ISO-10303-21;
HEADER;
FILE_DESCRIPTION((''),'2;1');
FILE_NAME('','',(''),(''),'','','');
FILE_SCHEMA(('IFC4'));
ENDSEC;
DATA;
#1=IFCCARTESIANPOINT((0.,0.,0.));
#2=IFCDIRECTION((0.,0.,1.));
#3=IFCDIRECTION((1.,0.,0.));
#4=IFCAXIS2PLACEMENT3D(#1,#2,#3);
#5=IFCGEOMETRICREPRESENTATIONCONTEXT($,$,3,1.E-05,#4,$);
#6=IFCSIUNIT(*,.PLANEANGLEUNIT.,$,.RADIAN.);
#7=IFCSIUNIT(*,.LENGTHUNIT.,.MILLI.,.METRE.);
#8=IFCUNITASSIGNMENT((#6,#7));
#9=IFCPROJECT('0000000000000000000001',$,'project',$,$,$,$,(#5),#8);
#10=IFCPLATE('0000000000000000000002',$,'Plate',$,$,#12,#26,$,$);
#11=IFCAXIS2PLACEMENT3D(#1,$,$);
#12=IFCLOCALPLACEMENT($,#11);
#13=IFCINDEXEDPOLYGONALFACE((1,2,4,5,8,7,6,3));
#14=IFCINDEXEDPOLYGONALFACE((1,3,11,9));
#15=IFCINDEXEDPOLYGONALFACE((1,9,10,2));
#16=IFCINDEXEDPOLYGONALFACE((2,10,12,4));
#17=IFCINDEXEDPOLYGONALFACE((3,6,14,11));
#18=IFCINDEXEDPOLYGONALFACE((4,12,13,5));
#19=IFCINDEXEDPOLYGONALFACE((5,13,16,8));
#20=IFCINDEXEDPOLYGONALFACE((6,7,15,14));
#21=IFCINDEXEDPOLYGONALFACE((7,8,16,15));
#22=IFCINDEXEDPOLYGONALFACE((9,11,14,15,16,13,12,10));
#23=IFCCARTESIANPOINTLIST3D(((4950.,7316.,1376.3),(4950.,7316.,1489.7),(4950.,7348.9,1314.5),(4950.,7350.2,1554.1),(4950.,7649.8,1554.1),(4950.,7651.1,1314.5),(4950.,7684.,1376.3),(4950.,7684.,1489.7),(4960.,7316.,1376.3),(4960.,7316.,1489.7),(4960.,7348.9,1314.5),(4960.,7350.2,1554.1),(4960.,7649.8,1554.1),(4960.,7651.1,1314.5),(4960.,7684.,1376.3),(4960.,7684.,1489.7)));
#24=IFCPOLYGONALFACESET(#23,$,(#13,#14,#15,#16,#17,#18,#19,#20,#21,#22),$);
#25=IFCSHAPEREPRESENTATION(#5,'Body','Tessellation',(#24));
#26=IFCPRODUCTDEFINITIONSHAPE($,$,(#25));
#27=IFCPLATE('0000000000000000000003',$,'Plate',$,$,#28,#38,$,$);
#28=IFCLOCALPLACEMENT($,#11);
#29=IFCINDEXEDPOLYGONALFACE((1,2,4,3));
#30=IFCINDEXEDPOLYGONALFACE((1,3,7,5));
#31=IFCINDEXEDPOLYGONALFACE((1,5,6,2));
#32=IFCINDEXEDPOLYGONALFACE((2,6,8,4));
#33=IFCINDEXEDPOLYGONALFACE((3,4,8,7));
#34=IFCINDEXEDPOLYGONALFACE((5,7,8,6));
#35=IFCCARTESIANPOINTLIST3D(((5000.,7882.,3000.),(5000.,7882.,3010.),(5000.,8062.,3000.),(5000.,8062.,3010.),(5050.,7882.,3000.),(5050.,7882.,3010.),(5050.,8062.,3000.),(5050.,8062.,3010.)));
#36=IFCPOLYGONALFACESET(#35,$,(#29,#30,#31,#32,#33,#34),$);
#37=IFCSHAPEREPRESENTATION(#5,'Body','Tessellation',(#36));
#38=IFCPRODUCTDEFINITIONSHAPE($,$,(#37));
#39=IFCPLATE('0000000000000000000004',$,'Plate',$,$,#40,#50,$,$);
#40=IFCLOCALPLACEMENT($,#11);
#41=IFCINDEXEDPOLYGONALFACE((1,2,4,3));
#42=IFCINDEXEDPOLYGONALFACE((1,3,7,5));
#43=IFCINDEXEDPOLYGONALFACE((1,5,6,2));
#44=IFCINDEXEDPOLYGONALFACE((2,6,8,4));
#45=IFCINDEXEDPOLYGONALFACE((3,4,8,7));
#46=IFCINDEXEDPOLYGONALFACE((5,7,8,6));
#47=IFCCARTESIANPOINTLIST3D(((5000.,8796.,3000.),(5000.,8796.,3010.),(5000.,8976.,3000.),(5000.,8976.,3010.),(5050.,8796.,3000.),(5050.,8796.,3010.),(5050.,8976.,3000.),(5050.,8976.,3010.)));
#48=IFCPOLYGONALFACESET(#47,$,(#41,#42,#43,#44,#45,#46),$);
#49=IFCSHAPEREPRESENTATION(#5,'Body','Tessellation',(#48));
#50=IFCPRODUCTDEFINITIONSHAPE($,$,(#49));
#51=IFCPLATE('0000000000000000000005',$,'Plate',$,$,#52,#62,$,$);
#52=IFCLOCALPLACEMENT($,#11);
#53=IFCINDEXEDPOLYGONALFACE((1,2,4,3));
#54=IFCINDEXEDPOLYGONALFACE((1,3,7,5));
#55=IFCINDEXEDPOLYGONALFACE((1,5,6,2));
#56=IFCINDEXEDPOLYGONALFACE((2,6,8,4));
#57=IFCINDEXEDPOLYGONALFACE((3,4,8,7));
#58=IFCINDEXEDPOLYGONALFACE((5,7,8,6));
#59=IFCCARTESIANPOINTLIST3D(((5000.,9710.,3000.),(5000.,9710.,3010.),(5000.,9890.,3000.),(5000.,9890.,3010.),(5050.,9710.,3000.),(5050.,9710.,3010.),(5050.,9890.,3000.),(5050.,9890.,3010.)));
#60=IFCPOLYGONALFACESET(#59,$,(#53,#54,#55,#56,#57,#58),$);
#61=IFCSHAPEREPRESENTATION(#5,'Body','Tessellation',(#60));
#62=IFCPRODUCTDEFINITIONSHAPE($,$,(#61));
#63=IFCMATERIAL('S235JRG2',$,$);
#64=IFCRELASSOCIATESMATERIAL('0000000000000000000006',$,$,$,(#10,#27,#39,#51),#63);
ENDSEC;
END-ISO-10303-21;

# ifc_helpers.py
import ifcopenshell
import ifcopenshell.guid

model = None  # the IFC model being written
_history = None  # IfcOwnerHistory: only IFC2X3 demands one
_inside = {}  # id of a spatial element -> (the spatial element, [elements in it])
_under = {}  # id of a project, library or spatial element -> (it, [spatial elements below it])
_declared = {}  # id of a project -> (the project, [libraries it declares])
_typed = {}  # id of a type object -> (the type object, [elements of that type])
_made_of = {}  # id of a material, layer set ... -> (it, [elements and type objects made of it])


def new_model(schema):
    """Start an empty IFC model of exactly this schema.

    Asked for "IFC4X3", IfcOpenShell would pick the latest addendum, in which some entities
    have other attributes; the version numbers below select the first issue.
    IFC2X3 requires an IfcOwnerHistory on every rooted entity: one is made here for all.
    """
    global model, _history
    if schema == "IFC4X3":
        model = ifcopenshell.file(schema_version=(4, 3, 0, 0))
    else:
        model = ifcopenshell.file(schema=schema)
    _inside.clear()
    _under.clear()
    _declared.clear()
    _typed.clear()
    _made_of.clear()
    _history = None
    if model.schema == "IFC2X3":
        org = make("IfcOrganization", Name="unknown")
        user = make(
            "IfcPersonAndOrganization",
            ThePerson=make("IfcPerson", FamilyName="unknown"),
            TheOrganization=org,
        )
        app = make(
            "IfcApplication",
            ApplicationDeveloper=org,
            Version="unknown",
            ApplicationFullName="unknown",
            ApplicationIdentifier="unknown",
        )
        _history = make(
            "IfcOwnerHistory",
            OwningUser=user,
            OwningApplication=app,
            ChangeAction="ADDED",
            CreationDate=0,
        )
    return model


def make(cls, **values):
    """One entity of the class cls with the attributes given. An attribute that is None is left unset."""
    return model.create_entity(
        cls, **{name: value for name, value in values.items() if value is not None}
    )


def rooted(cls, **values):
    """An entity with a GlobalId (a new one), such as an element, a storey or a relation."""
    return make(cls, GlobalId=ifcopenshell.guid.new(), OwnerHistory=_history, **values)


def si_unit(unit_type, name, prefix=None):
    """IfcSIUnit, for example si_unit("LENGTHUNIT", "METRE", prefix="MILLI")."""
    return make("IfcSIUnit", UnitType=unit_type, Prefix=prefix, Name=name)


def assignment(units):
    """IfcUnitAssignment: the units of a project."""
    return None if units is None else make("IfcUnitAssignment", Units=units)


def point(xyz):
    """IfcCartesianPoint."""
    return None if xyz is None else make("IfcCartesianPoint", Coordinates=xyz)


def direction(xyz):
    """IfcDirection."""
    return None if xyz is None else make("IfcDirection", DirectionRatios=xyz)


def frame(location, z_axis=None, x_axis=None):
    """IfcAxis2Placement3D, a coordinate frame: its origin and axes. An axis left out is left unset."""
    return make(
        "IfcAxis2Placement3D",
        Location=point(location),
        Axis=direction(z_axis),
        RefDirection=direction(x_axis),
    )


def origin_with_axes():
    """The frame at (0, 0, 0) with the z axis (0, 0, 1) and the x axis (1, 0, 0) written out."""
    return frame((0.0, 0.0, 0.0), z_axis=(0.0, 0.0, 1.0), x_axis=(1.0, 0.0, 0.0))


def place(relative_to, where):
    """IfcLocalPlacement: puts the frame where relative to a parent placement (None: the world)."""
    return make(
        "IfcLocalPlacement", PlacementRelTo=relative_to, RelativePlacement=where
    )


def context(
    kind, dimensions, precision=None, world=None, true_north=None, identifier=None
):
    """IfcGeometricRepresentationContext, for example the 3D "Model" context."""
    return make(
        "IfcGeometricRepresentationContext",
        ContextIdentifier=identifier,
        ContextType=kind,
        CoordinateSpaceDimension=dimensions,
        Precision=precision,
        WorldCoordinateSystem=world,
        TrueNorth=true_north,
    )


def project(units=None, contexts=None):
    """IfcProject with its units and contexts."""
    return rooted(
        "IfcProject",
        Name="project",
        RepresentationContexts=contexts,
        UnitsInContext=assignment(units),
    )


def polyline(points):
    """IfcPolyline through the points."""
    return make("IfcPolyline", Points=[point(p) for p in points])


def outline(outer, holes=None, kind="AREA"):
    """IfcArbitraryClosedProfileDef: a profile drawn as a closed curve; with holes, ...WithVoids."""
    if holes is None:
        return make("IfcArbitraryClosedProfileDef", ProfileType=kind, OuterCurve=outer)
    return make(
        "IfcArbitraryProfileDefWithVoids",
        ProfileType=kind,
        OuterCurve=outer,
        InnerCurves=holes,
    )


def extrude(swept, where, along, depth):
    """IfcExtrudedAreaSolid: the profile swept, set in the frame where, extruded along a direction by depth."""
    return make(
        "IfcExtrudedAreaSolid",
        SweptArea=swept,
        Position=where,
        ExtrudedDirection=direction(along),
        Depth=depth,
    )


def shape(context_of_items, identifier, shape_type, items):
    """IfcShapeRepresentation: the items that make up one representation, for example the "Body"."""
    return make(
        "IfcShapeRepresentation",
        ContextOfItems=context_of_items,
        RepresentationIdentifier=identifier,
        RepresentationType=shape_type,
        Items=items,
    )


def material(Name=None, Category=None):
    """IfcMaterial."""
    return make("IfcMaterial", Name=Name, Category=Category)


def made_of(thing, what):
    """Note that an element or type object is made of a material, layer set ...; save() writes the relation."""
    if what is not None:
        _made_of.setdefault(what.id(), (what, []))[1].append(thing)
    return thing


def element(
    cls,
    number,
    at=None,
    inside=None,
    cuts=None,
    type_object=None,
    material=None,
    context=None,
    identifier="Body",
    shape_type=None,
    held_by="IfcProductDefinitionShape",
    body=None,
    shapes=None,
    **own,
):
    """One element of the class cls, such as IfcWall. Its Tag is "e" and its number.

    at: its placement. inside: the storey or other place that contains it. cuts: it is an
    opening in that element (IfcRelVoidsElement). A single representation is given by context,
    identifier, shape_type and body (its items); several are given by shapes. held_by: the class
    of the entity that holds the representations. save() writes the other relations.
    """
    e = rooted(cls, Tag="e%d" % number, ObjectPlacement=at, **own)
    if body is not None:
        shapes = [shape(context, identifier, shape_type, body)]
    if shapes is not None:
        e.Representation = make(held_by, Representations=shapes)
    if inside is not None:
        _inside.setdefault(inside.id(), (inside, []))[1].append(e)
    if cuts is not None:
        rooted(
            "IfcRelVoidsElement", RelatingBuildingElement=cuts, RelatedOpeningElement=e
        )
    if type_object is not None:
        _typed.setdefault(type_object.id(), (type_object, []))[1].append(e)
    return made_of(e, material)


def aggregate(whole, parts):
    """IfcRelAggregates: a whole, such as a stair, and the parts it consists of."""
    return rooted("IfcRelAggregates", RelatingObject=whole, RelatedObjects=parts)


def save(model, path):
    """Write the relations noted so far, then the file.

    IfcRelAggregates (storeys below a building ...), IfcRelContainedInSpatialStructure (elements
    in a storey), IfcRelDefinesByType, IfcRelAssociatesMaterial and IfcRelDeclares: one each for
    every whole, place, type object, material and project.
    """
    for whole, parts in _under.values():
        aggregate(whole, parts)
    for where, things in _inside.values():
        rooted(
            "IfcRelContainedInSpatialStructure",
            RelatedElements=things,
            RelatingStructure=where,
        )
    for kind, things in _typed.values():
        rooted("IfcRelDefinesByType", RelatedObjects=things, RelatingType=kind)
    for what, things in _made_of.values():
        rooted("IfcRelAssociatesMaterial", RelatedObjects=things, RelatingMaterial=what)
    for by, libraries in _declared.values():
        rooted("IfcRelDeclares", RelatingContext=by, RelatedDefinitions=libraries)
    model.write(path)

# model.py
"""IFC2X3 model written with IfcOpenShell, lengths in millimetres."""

from ifc_helpers import new_model, si_unit, frame, origin_with_axes, place, context, project, polyline, outline, extrude, material, element, save


model = new_model("IFC2X3")

# Units and contexts
context_of_model = context(None, 3, precision=1e-05, world=origin_with_axes())
ifc_project = project(units=[si_unit("PLANEANGLEUNIT", "RADIAN"), si_unit("LENGTHUNIT", "METRE", prefix="MILLI")], contexts=[context_of_model])

# Shared definitions
ifc_material = material(Name="S235JRG2")

# Plates
placement_1 = place(None, frame((4950.0, 7684.0, 1376.3), z_axis=(0.0, -1.0, 0.0), x_axis=(1.0, 0.0, 0.0)))
plate_1_placement = place(placement_1, origin_with_axes())
element("IfcPlate", 1, at=plate_1_placement, material=ifc_material, Name="Plate", context=context_of_model, shape_type="SweptSolid", body=[
    extrude(outline(polyline([(0.0, 0.0), (113.4, 0.0), (177.8, 34.3), (177.8, 333.8), (113.4, 368.1), (0.0, 368.1), (-61.8, 335.2), (-61.8, 32.9), (0.0, 0.0)])), frame((0.0, 0.0, 0.0), z_axis=(1.0, 0.0, 0.0), x_axis=(0.0, 1.0, 0.0)), (0.0, 0.0, 1.0), 10.0),
])
placement_2 = place(None, origin_with_axes())
plate_2_placement = place(placement_2, frame((5000.0, 7882.0, 3010.0), z_axis=(1.0, 0.0, 0.0), x_axis=(0.0, 0.0, -1.0)))
element("IfcPlate", 2, at=plate_2_placement, material=ifc_material, Name="Plate", context=context_of_model, shape_type="SweptSolid", body=[
    extrude(outline(polyline([(0.0, 0.0), (180.0, 0.0), (180.0, 50.0), (0.0, 50.0), (0.0, 0.0)])), frame((0.0, 0.0, 0.0), z_axis=(1.0, 0.0, 0.0), x_axis=(0.0, 1.0, 0.0)), (0.0, 0.0, 1.0), 10.0),
])
placement_3 = place(None, origin_with_axes())
plate_3_placement = place(placement_3, frame((5000.0, 8796.0, 3010.0), z_axis=(1.0, 0.0, 0.0), x_axis=(0.0, 0.0, -1.0)))
element("IfcPlate", 3, at=plate_3_placement, material=ifc_material, Name="Plate", context=context_of_model, shape_type="SweptSolid", body=[
    extrude(outline(polyline([(0.0, 0.0), (180.0, 0.0), (180.0, 50.0), (0.0, 50.0), (0.0, 0.0)])), frame((0.0, 0.0, 0.0), z_axis=(1.0, 0.0, 0.0), x_axis=(0.0, 1.0, 0.0)), (0.0, 0.0, 1.0), 10.0),
])
placement_4 = place(None, origin_with_axes())
plate_4_placement = place(placement_4, frame((5000.0, 9710.0, 3010.0), z_axis=(1.0, 0.0, 0.0), x_axis=(0.0, 0.0, -1.0)))
element("IfcPlate", 4, at=plate_4_placement, material=ifc_material, Name="Plate", context=context_of_model, shape_type="SweptSolid", body=[
    extrude(outline(polyline([(0.0, 0.0), (180.0, 0.0), (180.0, 50.0), (0.0, 50.0), (0.0, 0.0)])), frame((0.0, 0.0, 0.0), z_axis=(1.0, 0.0, 0.0), x_axis=(0.0, 1.0, 0.0)), (0.0, 0.0, 1.0), 10.0),
])

save(model, "model.ifc")
